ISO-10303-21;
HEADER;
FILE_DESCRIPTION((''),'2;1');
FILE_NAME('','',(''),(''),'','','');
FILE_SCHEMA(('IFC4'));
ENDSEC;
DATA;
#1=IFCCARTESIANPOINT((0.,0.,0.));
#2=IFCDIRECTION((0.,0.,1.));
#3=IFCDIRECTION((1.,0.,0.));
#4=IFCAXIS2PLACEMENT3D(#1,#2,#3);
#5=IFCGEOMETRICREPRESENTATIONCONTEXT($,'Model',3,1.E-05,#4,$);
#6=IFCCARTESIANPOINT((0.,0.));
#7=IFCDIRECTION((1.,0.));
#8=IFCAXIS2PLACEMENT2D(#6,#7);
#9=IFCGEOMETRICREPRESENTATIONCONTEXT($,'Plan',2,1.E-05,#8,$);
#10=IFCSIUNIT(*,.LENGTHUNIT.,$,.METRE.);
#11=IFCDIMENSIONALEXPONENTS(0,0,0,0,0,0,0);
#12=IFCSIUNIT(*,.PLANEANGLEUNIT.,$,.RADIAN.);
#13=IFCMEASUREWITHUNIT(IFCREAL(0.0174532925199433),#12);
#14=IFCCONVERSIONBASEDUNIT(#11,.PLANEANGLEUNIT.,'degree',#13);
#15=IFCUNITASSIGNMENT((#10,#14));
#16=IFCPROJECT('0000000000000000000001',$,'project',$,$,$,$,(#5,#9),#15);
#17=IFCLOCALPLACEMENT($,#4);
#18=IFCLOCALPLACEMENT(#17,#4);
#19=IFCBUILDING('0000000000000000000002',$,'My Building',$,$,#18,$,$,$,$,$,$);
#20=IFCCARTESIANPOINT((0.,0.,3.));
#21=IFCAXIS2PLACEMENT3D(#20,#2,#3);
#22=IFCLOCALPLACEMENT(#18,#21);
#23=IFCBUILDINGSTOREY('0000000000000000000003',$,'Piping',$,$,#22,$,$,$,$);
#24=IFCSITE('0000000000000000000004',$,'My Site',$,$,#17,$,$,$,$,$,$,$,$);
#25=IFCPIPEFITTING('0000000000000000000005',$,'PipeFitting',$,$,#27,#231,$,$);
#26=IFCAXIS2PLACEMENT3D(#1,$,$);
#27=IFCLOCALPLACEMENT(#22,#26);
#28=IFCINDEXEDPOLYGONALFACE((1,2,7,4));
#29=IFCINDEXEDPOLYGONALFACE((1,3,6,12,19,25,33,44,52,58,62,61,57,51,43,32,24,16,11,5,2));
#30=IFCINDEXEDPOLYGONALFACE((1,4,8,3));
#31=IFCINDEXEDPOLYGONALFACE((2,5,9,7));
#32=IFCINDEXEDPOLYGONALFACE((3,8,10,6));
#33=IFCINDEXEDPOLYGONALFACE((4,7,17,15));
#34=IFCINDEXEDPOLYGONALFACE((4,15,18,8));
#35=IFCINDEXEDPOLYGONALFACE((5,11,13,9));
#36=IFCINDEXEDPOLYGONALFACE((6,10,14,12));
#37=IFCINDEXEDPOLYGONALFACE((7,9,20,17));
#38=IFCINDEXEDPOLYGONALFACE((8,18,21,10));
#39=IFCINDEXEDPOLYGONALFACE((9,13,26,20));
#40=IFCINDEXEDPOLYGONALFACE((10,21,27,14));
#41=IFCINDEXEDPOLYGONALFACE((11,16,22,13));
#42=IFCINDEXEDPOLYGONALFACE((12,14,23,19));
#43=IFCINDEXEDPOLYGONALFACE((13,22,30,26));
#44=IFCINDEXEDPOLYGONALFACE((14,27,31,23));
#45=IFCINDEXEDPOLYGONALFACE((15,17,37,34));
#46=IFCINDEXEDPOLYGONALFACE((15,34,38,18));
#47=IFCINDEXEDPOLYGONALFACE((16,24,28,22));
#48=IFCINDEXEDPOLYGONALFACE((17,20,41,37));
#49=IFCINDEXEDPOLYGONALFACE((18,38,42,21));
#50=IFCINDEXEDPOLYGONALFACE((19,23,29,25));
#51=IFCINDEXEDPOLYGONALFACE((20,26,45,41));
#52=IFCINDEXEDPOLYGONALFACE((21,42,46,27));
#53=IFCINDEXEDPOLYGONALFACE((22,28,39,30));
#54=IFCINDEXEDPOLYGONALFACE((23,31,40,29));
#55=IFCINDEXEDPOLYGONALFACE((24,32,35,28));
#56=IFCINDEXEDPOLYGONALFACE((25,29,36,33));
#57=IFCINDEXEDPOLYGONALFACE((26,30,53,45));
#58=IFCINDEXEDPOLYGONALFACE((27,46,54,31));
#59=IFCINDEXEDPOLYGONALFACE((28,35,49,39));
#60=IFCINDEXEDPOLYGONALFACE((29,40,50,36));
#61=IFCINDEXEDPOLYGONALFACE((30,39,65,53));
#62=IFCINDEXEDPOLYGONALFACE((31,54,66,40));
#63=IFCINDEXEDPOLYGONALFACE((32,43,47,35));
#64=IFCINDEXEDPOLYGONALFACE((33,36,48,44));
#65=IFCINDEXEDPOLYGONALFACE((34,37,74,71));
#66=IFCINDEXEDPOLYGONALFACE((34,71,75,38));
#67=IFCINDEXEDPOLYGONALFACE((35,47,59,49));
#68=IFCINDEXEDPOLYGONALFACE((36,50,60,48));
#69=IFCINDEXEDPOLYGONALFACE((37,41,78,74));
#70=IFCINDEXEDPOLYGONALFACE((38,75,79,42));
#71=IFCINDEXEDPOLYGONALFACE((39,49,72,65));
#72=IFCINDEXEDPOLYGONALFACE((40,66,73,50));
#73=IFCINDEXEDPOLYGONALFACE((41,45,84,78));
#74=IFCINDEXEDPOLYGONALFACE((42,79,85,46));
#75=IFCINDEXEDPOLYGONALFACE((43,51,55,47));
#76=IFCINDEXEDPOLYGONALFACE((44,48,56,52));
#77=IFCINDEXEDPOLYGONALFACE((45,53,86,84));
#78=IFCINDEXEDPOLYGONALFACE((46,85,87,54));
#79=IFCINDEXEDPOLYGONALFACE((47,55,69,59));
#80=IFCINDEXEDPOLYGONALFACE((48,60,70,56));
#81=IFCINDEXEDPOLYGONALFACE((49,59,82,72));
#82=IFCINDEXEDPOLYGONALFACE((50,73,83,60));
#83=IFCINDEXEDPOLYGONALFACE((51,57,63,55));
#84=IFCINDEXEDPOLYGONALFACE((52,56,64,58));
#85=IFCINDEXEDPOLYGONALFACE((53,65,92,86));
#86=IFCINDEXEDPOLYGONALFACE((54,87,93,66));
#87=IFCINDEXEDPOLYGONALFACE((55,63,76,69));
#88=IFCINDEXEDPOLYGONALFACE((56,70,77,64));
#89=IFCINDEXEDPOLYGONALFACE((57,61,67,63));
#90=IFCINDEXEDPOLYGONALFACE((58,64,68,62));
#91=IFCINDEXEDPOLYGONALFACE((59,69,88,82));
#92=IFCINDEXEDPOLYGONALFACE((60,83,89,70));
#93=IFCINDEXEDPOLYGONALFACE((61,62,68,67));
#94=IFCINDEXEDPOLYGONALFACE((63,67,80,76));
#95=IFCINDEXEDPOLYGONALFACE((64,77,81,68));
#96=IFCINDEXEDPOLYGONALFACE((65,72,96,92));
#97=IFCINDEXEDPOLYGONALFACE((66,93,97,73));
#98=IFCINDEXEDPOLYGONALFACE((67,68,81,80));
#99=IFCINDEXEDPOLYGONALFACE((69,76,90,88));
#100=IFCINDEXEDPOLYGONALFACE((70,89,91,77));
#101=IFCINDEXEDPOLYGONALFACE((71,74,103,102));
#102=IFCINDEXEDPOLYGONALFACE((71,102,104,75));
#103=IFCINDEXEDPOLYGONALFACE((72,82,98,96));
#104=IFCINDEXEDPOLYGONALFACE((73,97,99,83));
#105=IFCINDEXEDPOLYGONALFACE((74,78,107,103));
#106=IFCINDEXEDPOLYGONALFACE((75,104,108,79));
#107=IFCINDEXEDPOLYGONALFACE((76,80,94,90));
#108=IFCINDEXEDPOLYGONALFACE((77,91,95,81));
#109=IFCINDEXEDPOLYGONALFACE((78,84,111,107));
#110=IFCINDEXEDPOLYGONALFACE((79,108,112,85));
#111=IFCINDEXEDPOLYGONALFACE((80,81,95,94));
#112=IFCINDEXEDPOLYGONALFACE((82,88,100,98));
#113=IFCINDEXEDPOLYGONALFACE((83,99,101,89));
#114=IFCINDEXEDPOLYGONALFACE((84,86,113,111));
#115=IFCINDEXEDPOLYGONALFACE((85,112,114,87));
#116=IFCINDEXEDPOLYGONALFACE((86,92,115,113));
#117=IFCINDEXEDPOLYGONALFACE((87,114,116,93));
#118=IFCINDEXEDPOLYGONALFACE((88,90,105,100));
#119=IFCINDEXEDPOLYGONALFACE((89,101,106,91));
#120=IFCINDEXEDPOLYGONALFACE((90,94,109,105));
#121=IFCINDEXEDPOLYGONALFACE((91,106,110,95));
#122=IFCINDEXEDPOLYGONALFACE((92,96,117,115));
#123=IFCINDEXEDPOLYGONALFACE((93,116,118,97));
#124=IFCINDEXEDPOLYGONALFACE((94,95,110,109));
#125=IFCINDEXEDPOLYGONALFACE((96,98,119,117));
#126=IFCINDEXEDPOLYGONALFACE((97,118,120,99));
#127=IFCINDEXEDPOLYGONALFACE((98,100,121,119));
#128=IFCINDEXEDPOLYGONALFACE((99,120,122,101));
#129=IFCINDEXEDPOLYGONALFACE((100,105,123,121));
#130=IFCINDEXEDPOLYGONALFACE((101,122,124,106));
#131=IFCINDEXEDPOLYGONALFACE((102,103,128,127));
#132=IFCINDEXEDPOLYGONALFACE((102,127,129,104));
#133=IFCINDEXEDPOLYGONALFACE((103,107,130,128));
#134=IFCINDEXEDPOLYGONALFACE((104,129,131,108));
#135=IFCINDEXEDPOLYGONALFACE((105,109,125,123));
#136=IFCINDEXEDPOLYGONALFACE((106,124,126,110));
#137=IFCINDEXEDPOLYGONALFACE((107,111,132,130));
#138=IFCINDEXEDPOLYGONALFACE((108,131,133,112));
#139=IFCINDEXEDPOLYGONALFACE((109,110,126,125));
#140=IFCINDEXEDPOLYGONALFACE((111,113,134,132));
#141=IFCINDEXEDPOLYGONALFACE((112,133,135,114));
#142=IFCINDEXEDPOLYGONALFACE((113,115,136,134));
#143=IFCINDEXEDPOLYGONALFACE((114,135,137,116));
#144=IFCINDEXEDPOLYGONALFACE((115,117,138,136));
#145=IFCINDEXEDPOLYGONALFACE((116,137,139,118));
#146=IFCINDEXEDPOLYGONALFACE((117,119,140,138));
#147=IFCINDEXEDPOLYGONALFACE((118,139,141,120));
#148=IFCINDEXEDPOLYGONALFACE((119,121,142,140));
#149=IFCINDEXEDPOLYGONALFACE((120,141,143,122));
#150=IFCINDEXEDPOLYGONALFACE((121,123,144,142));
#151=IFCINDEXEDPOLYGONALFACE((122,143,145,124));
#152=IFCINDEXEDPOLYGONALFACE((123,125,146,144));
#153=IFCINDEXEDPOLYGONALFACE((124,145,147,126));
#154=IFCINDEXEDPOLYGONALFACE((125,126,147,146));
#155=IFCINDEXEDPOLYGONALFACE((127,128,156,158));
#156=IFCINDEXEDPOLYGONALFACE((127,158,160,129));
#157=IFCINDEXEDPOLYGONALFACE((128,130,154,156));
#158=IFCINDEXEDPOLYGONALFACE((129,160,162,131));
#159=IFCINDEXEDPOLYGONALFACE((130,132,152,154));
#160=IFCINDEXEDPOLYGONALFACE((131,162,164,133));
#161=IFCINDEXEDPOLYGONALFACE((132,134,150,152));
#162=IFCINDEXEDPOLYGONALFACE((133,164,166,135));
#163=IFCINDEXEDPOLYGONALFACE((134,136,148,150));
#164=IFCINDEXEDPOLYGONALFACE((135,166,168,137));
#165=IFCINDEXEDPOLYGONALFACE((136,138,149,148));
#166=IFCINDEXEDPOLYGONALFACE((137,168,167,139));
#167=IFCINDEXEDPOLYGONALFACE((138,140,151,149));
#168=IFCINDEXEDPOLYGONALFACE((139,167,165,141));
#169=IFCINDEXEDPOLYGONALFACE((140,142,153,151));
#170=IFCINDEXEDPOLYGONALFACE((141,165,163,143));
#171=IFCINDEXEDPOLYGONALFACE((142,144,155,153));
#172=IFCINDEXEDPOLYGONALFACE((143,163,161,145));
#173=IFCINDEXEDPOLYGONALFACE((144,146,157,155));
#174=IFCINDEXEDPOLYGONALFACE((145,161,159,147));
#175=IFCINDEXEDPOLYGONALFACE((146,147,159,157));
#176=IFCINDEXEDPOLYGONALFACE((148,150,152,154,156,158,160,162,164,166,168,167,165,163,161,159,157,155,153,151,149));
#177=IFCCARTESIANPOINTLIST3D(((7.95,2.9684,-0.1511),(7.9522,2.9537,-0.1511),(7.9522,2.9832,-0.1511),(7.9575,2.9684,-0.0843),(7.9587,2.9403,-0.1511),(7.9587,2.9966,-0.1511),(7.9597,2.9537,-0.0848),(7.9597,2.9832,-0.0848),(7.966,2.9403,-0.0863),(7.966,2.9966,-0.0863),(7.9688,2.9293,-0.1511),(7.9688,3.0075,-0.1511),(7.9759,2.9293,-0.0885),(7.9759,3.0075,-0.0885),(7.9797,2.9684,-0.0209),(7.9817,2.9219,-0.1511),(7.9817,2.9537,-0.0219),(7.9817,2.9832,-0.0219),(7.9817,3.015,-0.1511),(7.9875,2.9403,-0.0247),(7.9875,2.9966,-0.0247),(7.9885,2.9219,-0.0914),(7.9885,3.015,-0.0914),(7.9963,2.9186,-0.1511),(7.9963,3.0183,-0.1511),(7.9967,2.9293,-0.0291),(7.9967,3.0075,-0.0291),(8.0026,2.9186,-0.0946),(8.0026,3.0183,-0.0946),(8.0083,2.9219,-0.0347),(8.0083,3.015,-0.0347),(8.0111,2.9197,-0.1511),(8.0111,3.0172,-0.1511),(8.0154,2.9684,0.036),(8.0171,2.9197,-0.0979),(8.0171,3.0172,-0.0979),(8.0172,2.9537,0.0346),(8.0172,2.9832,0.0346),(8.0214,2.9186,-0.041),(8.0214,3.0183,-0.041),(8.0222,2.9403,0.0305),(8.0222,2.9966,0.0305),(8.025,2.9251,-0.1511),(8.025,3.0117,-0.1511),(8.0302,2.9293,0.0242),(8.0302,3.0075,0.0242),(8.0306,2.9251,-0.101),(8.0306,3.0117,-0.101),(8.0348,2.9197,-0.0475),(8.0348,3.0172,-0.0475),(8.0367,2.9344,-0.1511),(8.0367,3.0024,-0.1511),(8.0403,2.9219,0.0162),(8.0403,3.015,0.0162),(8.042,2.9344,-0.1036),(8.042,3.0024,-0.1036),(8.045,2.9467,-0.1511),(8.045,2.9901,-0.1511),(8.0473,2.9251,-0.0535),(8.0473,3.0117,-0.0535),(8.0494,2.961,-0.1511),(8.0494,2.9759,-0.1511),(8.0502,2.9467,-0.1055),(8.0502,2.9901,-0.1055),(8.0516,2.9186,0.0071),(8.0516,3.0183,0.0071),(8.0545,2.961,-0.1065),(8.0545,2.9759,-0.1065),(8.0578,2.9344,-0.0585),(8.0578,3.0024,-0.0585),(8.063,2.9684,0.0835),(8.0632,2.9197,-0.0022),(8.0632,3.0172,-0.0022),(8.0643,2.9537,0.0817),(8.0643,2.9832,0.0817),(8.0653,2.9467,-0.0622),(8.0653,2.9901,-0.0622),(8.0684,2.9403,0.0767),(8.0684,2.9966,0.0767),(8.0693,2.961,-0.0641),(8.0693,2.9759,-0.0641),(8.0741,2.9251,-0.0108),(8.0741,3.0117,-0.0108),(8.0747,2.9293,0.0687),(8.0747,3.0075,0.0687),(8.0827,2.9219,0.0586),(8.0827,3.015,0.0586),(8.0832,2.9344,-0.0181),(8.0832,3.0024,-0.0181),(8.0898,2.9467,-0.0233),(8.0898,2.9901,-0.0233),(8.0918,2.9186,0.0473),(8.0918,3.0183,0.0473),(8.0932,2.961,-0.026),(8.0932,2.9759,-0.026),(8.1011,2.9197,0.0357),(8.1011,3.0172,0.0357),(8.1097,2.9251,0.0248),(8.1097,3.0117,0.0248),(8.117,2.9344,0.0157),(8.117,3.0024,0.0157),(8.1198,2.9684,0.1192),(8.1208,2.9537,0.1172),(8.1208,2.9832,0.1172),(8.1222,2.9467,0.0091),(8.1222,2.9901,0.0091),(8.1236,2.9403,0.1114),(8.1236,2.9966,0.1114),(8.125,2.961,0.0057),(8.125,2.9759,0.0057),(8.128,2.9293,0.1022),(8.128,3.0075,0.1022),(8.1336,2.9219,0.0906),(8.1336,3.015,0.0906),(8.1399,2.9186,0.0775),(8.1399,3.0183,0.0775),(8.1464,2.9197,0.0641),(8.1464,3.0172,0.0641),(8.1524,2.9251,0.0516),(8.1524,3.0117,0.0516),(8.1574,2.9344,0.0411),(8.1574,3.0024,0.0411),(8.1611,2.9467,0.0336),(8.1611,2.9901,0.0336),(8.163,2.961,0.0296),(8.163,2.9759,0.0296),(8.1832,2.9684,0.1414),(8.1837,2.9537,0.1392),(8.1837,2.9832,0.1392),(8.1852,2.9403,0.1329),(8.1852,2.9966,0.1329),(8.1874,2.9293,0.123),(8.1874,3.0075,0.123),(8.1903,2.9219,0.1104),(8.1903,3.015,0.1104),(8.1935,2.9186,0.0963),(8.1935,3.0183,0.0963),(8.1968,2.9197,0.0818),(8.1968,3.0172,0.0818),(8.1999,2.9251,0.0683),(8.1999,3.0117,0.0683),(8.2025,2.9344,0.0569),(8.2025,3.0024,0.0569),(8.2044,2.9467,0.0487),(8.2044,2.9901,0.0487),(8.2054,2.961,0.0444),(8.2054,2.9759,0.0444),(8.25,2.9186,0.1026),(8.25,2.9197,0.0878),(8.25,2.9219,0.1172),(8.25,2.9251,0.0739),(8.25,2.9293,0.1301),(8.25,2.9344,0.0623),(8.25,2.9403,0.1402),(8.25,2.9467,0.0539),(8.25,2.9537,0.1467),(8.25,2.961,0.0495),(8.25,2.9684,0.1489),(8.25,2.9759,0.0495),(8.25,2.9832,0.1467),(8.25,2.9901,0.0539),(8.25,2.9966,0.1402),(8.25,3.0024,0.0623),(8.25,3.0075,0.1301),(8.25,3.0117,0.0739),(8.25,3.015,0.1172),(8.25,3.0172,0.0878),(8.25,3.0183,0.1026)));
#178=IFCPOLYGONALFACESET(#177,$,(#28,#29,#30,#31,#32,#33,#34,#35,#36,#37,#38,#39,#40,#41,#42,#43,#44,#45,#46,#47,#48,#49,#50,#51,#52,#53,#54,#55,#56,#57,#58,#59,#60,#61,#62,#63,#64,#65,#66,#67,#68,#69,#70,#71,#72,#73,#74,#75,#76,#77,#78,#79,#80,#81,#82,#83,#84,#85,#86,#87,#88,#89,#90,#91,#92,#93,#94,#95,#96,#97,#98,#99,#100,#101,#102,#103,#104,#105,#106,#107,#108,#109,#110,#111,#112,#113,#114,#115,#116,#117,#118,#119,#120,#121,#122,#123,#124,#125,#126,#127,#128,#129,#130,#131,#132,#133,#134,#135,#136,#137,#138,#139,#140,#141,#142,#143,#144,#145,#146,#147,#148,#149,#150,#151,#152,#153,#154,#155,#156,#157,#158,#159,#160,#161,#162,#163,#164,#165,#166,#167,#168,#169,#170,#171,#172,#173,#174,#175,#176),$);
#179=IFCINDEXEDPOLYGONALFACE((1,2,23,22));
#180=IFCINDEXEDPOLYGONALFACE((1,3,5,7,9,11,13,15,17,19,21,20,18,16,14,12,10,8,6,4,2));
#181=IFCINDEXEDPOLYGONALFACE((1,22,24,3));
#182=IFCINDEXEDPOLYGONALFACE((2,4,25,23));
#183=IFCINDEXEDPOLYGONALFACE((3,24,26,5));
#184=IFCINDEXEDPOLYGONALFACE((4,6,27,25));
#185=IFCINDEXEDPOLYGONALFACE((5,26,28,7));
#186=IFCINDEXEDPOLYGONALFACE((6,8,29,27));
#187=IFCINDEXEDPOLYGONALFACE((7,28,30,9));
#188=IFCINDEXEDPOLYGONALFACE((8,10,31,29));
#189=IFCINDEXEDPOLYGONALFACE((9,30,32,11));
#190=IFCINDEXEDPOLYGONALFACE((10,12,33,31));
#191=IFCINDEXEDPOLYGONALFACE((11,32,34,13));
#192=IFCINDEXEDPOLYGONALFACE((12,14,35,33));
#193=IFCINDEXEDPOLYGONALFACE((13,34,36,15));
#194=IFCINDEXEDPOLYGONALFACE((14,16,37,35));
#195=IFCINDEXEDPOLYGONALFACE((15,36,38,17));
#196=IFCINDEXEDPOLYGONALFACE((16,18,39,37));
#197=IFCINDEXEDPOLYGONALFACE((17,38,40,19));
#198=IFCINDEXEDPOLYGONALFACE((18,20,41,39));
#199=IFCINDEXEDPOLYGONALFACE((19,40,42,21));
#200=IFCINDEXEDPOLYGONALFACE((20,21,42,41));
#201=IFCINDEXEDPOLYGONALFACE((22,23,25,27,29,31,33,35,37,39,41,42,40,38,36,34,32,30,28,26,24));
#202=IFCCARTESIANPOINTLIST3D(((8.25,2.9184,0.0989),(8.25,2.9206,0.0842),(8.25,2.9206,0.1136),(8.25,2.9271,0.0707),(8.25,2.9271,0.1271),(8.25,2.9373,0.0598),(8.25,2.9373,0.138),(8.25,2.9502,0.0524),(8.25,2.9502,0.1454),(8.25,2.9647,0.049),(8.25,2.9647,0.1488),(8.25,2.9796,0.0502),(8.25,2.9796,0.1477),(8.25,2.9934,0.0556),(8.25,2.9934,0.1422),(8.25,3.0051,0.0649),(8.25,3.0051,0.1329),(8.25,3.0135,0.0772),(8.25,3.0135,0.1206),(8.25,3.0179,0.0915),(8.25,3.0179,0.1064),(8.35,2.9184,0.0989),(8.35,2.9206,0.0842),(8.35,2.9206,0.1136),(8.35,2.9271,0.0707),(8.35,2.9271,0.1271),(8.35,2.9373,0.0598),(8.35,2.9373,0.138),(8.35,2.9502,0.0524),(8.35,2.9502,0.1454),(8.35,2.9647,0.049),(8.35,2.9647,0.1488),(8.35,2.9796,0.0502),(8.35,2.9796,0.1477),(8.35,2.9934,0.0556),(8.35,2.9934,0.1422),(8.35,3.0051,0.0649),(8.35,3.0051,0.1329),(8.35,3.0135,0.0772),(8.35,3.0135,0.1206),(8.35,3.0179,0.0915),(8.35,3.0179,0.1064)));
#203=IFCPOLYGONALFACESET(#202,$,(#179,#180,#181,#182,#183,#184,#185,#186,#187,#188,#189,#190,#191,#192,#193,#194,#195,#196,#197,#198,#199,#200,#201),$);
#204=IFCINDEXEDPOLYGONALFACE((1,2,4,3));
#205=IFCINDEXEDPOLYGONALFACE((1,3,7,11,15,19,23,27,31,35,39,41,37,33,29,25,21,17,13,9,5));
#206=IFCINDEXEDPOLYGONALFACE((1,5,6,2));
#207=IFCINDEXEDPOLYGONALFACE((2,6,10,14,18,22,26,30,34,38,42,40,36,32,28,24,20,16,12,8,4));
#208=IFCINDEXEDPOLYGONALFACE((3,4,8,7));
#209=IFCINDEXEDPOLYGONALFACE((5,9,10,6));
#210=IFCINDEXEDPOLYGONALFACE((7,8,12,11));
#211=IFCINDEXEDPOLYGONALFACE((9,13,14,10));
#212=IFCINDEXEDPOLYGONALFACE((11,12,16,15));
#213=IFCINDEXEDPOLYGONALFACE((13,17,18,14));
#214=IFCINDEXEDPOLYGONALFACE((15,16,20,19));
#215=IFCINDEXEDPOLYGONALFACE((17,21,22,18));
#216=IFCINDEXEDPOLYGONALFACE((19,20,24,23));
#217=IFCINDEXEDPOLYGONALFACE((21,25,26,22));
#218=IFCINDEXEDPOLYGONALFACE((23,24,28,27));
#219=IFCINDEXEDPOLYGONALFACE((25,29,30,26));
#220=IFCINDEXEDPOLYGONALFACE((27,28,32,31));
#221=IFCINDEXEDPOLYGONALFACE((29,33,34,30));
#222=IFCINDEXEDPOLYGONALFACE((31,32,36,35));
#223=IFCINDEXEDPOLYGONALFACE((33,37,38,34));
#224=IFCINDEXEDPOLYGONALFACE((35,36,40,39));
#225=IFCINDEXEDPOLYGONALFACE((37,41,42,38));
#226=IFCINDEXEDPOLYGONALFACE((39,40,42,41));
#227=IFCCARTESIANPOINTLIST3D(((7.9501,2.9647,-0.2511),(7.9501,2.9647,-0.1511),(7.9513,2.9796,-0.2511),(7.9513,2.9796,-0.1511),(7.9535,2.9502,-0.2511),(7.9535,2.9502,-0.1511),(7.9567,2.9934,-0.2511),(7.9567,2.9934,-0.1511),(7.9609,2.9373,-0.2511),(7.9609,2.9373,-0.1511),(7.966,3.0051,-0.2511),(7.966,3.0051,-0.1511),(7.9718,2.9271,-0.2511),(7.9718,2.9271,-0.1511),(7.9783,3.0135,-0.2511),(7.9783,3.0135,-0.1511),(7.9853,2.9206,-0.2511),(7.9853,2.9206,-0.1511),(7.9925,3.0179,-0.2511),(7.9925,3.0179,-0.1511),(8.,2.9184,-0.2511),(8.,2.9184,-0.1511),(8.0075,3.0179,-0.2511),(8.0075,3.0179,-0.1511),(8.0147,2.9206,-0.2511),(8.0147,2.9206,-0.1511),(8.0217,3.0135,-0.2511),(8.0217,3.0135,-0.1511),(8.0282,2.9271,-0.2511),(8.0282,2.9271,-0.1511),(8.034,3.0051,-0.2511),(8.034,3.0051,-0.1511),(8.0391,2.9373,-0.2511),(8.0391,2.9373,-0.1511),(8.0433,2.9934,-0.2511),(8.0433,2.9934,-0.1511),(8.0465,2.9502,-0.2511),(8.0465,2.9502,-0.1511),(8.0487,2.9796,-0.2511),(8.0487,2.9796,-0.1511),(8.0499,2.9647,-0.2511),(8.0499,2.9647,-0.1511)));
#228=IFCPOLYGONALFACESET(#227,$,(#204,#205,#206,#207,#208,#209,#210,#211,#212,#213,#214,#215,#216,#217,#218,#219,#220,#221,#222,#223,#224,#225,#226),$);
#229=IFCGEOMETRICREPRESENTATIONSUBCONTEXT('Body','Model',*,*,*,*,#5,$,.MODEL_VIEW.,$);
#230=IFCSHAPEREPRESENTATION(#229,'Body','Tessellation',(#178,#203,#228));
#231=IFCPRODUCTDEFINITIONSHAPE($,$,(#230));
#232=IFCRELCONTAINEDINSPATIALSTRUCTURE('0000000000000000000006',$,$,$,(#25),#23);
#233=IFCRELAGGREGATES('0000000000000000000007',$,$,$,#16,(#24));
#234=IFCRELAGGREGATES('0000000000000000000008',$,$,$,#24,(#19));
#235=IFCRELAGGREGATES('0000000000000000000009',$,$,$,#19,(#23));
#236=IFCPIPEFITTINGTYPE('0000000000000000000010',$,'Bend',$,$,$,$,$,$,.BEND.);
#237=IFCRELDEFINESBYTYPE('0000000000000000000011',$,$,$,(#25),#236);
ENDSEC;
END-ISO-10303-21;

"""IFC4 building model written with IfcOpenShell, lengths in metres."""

from ifc_helpers import new_model, entity, si_unit, converted_unit, frame, origin_with_axes, origin_2d_with_axis, place, context, subcontext, project, spatial, circle, extrude, source, transform, mapped, type_object, type_shapes, element, save


model = new_model("IFC4")

# Units and contexts
model_context = context("Model", 3, precision=1e-05, world=origin_with_axes())
plan_context = context("Plan", 2, precision=1e-05, world=origin_2d_with_axis())
body_context = subcontext(model_context, "Body", "Model", "MODEL_VIEW")
ifc_project = project(units=[si_unit("LENGTHUNIT", "METRE"), converted_unit("PLANEANGLEUNIT", "degree", entity("IfcReal", 0.0174532925199433), si_unit("PLANEANGLEUNIT", "RADIAN"), dimensions=[0, 0, 0, 0, 0, 0, 0])], contexts=[model_context, plan_context])

# Site, building, storey
site_placement = place(None, origin_with_axes())
site = spatial("IfcSite", under=ifc_project, at=site_placement, Name="My Site")
building_placement = place(site_placement, origin_with_axes())
building = spatial("IfcBuilding", under=site, at=building_placement, Name="My Building")
storey_placement = place(building_placement, frame((0.0, 0.0, 3.0), z_axis=(0.0, 0.0, 1.0), x_axis=(1.0, 0.0, 0.0)))
storey = spatial("IfcBuildingStorey", under=building, at=storey_placement, Name="Piping")

# Pipe fitting
pipe_fitting_type_1 = type_object("IfcPipeFittingType", Name="Bend", PredefinedType="BEND")
shared_shape_1 = source(origin_with_axes(), body_context, "Body", "SolidModel", [
    entity("IfcSweptDiskSolid", entity("IfcIndexedPolyCurve", entity("IfcCartesianPointList3D", [[0.0, 0.0, 0.1], [0.0, -0.0732, 0.2768], [0.0, -0.25, 0.35]]), [entity("IfcArcIndex", [1, 2, 3])]), 0.05),
    extrude(circle(Radius=0.05), origin_with_axes(), (0.0, 0.0, 1.0), 0.1),
    extrude(circle(Radius=0.05), frame((0.0, -0.25, 0.35), z_axis=(0.0, -1.0, 0.0), x_axis=(1.0, 0.0, 0.0)), (0.0, 0.0, 1.0), 0.1),
])
type_shapes(pipe_fitting_type_1, [shared_shape_1])
for number, where, z_axis, x_axis, name in (
    (1, (8.35, 2.9684, 0.0989), (-1.0, 0.0, 0.0), (0.0, -1.0, 0.0), "PipeFitting"),
):
    element("IfcPipeFitting", number, at=place(storey_placement, frame(where, z_axis=z_axis, x_axis=x_axis)), inside=storey, type_object=pipe_fitting_type_1, Name=name, context=body_context, shape_type="MappedRepresentation", body=[
        mapped(shared_shape_1, transform((0.0, 0.0, 0.0), x_axis=(1.0, 0.0, 0.0), y_axis=(0.0, 1.0, 0.0), z_axis=(0.0, 0.0, 1.0), scale=1.0)),
    ])

save(model, "model.ifc")
